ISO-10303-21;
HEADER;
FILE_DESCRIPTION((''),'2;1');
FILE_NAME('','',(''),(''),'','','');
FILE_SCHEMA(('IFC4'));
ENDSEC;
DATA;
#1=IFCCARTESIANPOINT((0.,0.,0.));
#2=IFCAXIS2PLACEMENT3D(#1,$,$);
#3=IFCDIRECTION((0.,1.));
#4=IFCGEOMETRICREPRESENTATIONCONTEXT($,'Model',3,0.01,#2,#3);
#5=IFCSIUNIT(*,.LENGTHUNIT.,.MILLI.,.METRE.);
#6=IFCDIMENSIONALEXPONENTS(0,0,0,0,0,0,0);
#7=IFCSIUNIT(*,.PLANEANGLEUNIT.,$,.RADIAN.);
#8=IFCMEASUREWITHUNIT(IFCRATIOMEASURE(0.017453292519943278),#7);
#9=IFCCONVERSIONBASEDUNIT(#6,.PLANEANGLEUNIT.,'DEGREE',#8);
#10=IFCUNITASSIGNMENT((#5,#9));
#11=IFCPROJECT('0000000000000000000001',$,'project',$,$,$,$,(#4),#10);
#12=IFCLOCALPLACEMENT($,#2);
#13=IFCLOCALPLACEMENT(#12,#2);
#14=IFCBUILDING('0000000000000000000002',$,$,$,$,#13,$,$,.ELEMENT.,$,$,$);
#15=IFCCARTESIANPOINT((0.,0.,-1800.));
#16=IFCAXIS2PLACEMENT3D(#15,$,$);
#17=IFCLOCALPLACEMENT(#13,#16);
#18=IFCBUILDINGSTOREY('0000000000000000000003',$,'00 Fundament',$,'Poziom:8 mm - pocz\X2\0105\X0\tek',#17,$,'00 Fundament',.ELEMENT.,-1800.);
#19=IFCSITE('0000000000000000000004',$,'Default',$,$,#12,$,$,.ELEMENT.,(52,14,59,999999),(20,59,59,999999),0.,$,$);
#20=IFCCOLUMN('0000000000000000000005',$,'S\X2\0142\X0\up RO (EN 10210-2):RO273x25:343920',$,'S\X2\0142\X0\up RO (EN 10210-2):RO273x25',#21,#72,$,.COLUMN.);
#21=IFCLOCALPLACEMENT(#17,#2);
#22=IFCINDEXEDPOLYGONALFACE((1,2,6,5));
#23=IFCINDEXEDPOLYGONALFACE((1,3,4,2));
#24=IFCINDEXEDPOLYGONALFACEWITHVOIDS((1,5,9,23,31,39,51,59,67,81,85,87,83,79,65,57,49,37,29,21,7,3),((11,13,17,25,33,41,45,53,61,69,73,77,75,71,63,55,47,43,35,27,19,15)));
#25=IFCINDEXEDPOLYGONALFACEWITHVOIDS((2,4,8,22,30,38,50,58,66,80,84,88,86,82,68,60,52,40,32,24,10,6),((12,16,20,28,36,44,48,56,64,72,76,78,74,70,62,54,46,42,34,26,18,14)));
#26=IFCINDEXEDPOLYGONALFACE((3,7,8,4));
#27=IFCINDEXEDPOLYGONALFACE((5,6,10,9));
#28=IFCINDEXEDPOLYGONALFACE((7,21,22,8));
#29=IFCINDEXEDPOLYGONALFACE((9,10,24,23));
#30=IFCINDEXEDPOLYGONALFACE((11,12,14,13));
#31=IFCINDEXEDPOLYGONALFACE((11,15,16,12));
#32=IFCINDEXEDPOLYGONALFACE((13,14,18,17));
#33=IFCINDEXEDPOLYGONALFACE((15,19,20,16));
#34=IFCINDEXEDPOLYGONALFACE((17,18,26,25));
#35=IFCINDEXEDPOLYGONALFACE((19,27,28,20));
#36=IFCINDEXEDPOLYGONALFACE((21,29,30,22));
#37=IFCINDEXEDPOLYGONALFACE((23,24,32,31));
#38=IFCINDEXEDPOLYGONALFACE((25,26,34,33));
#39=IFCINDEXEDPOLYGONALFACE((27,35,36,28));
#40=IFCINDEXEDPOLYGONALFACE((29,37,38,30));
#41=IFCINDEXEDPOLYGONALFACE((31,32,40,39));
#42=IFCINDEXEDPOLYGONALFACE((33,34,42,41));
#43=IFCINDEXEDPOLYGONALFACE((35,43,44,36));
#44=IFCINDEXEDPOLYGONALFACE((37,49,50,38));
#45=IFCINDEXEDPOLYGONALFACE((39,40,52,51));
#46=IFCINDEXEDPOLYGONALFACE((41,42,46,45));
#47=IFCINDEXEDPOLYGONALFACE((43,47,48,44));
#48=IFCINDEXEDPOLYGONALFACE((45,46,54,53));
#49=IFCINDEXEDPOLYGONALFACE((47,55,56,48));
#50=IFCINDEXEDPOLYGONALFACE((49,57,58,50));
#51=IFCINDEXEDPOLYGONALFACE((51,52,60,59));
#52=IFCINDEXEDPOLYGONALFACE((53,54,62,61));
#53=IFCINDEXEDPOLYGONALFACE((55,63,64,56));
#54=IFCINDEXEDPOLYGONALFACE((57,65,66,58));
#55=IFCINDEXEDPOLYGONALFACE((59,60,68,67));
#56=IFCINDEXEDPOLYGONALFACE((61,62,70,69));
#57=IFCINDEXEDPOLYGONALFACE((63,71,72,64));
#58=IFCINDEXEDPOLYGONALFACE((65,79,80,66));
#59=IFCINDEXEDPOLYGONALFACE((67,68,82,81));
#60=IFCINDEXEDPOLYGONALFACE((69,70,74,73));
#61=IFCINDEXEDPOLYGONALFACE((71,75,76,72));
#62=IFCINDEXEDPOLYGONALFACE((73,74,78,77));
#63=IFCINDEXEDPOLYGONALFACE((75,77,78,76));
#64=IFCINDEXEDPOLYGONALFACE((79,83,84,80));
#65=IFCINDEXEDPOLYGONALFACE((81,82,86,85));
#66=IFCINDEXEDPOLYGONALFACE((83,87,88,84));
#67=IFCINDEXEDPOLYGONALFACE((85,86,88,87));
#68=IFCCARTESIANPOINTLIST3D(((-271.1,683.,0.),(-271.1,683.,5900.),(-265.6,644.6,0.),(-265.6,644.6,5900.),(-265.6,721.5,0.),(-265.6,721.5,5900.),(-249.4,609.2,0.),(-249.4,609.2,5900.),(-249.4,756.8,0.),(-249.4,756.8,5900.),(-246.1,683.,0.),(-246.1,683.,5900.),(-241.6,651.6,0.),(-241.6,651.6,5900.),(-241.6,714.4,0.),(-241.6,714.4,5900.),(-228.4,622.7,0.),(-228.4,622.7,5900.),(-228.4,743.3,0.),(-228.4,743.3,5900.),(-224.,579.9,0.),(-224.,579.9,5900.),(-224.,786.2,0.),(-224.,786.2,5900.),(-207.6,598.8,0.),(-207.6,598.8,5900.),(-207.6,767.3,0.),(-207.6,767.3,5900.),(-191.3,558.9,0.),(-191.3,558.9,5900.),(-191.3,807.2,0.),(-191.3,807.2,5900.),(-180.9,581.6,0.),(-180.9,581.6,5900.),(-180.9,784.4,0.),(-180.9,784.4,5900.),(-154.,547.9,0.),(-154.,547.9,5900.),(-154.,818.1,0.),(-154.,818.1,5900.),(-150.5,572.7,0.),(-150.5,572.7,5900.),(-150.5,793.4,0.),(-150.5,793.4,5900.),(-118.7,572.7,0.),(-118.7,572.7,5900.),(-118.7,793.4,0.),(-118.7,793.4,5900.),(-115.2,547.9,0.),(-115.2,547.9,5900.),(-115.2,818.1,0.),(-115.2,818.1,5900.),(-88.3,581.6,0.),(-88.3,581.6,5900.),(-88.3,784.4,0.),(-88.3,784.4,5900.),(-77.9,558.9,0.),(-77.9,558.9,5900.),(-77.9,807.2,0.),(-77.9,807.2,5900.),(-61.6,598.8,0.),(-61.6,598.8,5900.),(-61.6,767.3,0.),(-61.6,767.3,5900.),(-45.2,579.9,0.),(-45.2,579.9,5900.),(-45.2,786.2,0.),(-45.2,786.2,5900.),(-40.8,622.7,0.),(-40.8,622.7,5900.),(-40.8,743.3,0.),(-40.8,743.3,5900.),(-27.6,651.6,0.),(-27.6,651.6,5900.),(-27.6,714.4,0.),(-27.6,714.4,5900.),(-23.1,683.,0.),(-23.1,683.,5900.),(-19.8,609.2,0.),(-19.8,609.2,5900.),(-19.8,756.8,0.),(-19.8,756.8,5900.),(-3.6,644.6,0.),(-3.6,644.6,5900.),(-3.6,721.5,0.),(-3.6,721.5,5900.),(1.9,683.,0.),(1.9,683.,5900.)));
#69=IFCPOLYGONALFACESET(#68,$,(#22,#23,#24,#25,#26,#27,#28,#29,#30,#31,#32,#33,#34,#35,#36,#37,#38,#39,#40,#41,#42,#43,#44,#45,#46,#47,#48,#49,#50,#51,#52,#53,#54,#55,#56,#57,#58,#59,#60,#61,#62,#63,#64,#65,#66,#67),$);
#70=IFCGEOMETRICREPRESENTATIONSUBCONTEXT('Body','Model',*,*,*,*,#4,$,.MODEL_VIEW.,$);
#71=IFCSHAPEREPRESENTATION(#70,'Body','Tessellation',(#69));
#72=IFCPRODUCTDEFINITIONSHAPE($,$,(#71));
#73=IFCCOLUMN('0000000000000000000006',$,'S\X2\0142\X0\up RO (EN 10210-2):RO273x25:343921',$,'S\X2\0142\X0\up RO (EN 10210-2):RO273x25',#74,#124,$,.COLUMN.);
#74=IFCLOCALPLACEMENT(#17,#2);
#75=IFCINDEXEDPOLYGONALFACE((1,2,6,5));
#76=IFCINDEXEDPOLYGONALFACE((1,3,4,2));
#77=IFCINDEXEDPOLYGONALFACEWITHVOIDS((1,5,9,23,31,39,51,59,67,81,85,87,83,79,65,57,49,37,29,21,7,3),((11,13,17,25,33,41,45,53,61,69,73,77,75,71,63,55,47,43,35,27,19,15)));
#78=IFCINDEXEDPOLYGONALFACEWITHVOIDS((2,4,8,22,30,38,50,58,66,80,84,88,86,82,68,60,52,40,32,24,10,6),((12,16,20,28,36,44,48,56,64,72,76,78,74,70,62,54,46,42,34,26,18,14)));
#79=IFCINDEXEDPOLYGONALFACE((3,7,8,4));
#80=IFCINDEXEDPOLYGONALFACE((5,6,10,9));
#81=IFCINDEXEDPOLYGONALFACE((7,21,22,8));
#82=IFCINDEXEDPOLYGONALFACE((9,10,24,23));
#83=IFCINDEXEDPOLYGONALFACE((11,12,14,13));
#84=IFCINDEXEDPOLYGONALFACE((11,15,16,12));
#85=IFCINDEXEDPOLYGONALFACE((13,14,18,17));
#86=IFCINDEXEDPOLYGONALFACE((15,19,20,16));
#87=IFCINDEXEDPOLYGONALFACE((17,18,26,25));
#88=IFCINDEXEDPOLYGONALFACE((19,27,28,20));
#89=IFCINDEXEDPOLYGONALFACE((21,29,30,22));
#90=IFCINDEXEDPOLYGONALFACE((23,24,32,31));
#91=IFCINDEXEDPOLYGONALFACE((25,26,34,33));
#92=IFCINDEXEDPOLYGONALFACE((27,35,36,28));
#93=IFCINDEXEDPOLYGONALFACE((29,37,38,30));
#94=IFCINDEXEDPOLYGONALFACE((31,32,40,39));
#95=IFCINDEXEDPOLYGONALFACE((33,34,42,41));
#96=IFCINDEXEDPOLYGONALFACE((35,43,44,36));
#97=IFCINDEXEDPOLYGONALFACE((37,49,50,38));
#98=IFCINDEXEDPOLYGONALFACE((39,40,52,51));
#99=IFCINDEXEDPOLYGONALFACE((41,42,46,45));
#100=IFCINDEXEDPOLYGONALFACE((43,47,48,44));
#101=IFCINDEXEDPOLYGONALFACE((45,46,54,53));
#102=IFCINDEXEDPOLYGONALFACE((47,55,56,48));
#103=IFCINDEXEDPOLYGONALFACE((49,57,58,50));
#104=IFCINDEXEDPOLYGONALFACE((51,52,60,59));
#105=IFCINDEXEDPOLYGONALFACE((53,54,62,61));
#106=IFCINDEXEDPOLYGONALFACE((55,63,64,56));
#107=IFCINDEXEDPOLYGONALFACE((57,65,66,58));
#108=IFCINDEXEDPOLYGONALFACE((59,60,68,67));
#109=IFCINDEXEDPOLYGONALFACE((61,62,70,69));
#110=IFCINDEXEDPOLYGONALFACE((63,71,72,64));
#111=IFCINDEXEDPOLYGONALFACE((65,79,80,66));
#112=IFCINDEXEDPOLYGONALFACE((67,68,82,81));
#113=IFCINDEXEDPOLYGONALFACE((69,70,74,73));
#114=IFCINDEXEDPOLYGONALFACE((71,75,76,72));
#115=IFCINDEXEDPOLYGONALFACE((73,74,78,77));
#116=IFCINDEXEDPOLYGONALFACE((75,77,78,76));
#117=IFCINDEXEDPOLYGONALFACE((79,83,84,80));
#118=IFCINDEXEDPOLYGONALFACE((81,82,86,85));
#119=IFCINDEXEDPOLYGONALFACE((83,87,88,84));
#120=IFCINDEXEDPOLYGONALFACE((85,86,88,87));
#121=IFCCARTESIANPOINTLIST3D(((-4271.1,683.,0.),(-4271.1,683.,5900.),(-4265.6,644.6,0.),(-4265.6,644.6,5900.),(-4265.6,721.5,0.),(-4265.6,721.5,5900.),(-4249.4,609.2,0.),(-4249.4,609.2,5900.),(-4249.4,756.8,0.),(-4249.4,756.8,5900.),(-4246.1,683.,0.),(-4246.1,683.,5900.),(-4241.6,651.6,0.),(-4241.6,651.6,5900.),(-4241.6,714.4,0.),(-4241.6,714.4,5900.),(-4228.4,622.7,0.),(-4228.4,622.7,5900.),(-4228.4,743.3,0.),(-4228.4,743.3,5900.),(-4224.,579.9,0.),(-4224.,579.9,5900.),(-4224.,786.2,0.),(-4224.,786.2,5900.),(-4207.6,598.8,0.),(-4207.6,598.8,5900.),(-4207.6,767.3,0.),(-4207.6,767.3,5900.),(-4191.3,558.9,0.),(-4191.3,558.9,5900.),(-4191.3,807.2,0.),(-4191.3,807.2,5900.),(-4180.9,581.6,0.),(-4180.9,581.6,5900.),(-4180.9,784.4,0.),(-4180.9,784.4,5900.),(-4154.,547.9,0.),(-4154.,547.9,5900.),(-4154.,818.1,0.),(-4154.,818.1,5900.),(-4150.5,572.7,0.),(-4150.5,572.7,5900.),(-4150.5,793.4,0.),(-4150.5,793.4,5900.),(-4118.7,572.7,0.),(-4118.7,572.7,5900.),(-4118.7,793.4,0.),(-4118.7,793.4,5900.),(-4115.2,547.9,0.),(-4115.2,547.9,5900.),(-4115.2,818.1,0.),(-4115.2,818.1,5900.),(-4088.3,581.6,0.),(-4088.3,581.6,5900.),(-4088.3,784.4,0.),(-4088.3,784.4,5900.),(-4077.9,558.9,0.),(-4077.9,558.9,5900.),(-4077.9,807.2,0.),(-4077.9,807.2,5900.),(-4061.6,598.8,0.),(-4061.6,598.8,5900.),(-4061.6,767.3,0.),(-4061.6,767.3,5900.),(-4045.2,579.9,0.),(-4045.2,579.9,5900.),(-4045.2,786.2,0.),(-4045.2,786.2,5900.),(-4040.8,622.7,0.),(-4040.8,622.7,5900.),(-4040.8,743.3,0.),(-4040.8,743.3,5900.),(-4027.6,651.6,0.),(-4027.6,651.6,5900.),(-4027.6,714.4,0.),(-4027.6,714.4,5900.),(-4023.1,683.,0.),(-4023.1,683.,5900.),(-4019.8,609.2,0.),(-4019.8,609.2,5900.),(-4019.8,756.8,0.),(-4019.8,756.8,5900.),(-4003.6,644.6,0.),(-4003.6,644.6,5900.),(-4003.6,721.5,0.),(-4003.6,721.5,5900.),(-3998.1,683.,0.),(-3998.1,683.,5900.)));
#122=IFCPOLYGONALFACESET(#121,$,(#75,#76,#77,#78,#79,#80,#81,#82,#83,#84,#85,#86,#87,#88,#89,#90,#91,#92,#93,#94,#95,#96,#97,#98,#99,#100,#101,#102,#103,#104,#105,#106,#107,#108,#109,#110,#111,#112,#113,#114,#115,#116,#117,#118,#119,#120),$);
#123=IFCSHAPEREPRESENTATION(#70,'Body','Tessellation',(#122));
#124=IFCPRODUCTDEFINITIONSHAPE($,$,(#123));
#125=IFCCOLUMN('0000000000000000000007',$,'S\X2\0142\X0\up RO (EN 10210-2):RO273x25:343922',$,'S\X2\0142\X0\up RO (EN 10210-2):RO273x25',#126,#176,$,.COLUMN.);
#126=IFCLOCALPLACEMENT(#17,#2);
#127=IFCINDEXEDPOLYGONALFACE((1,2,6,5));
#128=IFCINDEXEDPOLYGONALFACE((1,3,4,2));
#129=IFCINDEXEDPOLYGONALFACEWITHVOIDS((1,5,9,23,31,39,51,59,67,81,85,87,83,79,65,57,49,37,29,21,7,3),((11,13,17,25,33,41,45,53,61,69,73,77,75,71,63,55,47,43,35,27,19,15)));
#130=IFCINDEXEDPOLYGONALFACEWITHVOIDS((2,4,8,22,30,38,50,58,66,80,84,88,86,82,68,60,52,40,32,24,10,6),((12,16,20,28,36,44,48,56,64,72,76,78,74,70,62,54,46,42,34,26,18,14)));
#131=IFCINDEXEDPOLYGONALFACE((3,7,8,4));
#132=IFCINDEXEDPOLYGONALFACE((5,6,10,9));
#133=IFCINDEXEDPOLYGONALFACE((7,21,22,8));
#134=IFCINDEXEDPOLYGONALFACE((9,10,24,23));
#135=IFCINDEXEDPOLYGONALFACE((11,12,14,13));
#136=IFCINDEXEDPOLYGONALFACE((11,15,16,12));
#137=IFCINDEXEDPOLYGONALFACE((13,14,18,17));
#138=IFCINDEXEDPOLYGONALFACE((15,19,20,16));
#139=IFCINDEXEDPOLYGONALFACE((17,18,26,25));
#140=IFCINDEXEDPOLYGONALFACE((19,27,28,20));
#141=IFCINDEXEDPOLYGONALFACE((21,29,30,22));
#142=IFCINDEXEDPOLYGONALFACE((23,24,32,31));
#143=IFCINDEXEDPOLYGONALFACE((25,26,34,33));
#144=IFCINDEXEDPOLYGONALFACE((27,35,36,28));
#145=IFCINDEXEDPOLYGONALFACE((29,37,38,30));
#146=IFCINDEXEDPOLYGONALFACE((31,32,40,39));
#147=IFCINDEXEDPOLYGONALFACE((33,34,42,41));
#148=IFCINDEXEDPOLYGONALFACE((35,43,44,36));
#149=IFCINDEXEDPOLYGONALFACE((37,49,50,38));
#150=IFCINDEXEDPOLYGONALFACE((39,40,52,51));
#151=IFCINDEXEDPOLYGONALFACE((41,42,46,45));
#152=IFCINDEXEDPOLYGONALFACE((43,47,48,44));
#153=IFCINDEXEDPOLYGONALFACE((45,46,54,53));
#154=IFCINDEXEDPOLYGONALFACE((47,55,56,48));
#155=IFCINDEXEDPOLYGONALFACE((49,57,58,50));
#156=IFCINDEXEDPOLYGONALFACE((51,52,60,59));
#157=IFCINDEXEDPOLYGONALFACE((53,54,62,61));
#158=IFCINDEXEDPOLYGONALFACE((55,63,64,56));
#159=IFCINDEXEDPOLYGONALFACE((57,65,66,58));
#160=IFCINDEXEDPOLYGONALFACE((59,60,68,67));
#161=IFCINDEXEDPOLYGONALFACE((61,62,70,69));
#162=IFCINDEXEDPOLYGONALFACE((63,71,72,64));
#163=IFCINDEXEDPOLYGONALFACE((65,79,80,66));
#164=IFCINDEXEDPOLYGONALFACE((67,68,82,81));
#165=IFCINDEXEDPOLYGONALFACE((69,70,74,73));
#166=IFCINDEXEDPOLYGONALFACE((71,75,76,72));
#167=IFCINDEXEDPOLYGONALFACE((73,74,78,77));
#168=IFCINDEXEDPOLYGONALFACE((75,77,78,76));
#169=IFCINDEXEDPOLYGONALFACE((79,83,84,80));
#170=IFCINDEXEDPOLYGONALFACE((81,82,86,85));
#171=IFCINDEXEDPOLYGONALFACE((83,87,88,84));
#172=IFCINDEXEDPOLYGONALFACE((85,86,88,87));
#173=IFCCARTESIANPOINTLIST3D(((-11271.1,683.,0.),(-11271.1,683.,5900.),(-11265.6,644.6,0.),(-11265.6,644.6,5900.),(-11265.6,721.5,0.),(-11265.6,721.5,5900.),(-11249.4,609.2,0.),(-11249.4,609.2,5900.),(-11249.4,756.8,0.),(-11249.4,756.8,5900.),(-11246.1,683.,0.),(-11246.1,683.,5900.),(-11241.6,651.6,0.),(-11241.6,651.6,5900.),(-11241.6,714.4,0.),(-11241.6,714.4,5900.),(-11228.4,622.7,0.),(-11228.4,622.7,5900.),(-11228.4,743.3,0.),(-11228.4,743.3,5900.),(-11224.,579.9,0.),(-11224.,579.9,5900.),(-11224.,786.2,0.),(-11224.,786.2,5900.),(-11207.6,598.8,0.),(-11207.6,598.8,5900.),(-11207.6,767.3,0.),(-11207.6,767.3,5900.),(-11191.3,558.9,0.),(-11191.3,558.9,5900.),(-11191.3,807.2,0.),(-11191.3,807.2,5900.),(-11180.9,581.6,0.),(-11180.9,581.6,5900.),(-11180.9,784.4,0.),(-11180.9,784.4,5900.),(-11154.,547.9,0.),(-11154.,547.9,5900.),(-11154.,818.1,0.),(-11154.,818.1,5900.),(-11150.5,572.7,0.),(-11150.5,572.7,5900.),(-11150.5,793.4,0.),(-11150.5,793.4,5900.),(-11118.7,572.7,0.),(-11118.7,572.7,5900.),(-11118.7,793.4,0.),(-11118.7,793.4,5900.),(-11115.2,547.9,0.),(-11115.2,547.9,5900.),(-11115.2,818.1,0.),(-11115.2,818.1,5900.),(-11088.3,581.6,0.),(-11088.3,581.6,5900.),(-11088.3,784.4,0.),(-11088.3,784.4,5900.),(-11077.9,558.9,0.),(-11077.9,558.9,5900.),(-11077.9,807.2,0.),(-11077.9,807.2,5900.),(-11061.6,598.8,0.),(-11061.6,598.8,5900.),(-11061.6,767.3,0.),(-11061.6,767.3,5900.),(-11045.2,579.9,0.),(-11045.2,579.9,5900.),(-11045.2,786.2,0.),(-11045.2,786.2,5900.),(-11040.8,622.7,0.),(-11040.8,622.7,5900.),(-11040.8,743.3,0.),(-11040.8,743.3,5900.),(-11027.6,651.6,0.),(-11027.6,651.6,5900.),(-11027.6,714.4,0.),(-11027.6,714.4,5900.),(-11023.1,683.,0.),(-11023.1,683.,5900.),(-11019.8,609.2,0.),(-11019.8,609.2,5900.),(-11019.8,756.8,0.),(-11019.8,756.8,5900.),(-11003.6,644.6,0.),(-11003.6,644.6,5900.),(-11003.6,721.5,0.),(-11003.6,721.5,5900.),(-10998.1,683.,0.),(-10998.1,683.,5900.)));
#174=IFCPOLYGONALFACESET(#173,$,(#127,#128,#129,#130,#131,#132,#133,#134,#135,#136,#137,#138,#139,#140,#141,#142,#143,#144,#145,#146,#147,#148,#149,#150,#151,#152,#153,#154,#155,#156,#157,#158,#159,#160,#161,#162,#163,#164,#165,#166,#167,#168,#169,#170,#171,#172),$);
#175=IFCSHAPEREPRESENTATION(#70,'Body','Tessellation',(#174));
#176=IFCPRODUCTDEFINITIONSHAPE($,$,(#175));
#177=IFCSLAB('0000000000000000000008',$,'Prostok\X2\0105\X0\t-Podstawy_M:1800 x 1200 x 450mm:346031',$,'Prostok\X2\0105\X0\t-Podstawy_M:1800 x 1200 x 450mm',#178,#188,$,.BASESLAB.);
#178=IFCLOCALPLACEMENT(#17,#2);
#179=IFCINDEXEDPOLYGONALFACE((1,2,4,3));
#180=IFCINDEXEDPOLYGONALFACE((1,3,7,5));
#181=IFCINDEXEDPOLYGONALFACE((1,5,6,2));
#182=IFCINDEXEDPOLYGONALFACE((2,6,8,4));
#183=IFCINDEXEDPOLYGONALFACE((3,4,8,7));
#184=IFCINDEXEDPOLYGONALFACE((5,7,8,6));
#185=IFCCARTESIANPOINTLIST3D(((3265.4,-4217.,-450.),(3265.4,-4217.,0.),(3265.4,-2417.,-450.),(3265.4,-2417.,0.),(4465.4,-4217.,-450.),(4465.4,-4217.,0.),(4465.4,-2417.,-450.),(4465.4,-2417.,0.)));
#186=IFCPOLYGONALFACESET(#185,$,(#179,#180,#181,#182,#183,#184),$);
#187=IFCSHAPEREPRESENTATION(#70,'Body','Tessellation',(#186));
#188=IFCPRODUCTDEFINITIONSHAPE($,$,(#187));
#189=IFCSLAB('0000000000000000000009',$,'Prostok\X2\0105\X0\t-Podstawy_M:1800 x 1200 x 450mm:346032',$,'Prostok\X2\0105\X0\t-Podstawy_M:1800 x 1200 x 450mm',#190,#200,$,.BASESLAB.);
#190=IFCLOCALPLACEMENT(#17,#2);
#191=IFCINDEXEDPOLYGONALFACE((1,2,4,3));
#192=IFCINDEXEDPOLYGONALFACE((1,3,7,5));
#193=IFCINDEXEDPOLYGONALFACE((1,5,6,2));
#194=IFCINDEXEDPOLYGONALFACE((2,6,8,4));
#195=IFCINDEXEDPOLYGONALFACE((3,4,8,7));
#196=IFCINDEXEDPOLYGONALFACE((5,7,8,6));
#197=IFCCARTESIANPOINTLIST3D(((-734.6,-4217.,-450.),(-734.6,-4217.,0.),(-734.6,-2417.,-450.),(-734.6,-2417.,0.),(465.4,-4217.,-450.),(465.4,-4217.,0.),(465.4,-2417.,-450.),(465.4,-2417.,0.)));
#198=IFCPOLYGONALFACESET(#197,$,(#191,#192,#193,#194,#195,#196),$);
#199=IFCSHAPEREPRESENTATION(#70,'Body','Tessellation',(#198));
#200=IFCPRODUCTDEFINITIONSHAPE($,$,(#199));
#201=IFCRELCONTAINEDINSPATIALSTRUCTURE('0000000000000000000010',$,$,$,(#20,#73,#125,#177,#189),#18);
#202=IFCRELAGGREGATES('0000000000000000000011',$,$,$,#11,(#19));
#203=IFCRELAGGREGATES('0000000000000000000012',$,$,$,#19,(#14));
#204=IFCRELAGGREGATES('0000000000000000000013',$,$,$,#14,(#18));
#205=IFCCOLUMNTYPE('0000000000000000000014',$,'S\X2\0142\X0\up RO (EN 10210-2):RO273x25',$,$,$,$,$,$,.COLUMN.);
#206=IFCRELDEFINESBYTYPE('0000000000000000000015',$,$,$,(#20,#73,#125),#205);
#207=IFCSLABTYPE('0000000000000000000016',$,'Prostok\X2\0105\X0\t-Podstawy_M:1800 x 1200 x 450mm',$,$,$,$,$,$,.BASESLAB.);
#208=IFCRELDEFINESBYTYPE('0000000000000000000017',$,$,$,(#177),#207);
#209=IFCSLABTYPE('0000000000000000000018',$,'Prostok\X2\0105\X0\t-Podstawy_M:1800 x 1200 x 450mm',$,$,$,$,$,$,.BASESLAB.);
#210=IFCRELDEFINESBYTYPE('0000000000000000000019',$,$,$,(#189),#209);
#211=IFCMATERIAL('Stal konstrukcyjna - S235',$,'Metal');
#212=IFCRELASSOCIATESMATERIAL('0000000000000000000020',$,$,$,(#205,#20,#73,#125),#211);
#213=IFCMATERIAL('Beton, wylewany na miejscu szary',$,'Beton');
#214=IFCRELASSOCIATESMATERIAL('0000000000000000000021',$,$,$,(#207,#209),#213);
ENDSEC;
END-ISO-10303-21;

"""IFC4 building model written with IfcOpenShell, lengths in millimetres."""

from ifc_helpers import new_model, entity, si_unit, converted_unit, direction, frame, origin, place, context, subcontext, project, spatial, arc, indexed_curve, outline, extrude, source, transform, mapped, material, type_object, type_shapes, element, save


model = new_model("IFC4")

# Units and contexts
model_context = context("Model", 3, precision=0.01, world=origin(), true_north=direction((0.0, 1.0)))
body_context = subcontext(model_context, "Body", "Model", "MODEL_VIEW")
ifc_project = project(units=[si_unit("LENGTHUNIT", "METRE", prefix="MILLI"), converted_unit("PLANEANGLEUNIT", "DEGREE", entity("IfcRatioMeasure", 0.017453292519943278), si_unit("PLANEANGLEUNIT", "RADIAN"), dimensions=[0, 0, 0, 0, 0, 0, 0])], contexts=[model_context])

# Site, building, storey
site_placement = place(None, origin())
site = spatial("IfcSite", under=ifc_project, at=site_placement, Name="Default", CompositionType="ELEMENT", RefLatitude=(52, 14, 59, 999999), RefLongitude=(20, 59, 59, 999999), RefElevation=0.0)
building_placement = place(site_placement, origin())
building = spatial("IfcBuilding", under=site, at=building_placement, CompositionType="ELEMENT")
storey_placement = place(building_placement, frame((0.0, 0.0, -1800.0)))
storey = spatial("IfcBuildingStorey", under=building, at=storey_placement, Name="00 Fundament", ObjectType="Poziom:8 mm - początek", LongName="00 Fundament", CompositionType="ELEMENT", Elevation=-1800.0)

# Columns
ifc_material_1 = material(Name="Stal konstrukcyjna - S235", Category="Metal")
column_type = type_object("IfcColumnType", Name="Słup RO (EN 10210-2):RO273x25", PredefinedType="COLUMN", material=ifc_material_1)
shared_shape = source(origin(), body_context, "Body", "SweptSolid", [
    extrude(outline(indexed_curve([(-136.5, 0.0), (0.0, -136.5), (136.5, 0.0), (0.0, 136.5)], segments=[arc(1, 2, 3), arc(3, 4, 1)], self_intersect=False), holes=[indexed_curve([(-111.5, 0.0), (0.0, 111.5), (111.5, 0.0), (0.0, -111.5)], segments=[arc(1, 2, 3), arc(3, 4, 1)], self_intersect=False)]), frame((0.0, 0.0, -1800.0)), (0.0, 0.0, 1.0), 5900.0),
])
type_shapes(column_type, [shared_shape])
for number, where, name in (
    (1, (-134.6, 683.0, 1800.0), "Słup RO (EN 10210-2):RO273x25:343920"),
    (2, (-4134.6, 683.0, 1800.0), "Słup RO (EN 10210-2):RO273x25:343921"),
    (3, (-11134.6, 683.0, 1800.0), "Słup RO (EN 10210-2):RO273x25:343922"),
):
    element("IfcColumn", number, at=place(storey_placement, frame(where)), inside=storey, type_object=column_type, material=ifc_material_1, Name=name, ObjectType="Słup RO (EN 10210-2):RO273x25", PredefinedType="COLUMN", context=body_context, shape_type="MappedRepresentation", body=[
        mapped(shared_shape, transform((0.0, 0.0, 0.0), scale=1.0)),
    ])

# Slabs
ifc_material_2 = material(Name="Beton, wylewany na miejscu szary", Category="Beton")
slab_type_1 = type_object("IfcSlabType", Name="Prostokąt-Podstawy_M:1800 x 1200 x 450mm", PredefinedType="BASESLAB", material=ifc_material_2)
slab_1_placement = place(storey_placement, origin())
element("IfcSlab", 4, at=slab_1_placement, inside=storey, type_object=slab_type_1, Name="Prostokąt-Podstawy_M:1800 x 1200 x 450mm:346031", ObjectType="Prostokąt-Podstawy_M:1800 x 1200 x 450mm", PredefinedType="BASESLAB", context=body_context, shape_type="SweptSolid", body=[
    extrude(outline(indexed_curve([(-600.0, -900.0), (600.0, -900.0), (600.0, 900.0), (-600.0, 900.0), (-600.0, -900.0)], self_intersect=False)), frame((3865.4, -3317.0, -450.0), z_axis=(0.0, 0.0, 1.0), x_axis=(-1.0, 0.0, 0.0)), (0.0, 0.0, 1.0), 450.0),
])
slab_type_2 = type_object("IfcSlabType", Name="Prostokąt-Podstawy_M:1800 x 1200 x 450mm", PredefinedType="BASESLAB", material=ifc_material_2)
slab_2_placement = place(storey_placement, origin())
element("IfcSlab", 5, at=slab_2_placement, inside=storey, type_object=slab_type_2, Name="Prostokąt-Podstawy_M:1800 x 1200 x 450mm:346032", ObjectType="Prostokąt-Podstawy_M:1800 x 1200 x 450mm", PredefinedType="BASESLAB", context=body_context, shape_type="SweptSolid", body=[
    extrude(outline(indexed_curve([(-600.0, -900.0), (600.0, -900.0), (600.0, 900.0), (-600.0, 900.0), (-600.0, -900.0)], self_intersect=False)), frame((-134.6, -3317.0, -450.0), z_axis=(0.0, 0.0, 1.0), x_axis=(-1.0, 0.0, 0.0)), (0.0, 0.0, 1.0), 450.0),
])

save(model, "model.ifc")
